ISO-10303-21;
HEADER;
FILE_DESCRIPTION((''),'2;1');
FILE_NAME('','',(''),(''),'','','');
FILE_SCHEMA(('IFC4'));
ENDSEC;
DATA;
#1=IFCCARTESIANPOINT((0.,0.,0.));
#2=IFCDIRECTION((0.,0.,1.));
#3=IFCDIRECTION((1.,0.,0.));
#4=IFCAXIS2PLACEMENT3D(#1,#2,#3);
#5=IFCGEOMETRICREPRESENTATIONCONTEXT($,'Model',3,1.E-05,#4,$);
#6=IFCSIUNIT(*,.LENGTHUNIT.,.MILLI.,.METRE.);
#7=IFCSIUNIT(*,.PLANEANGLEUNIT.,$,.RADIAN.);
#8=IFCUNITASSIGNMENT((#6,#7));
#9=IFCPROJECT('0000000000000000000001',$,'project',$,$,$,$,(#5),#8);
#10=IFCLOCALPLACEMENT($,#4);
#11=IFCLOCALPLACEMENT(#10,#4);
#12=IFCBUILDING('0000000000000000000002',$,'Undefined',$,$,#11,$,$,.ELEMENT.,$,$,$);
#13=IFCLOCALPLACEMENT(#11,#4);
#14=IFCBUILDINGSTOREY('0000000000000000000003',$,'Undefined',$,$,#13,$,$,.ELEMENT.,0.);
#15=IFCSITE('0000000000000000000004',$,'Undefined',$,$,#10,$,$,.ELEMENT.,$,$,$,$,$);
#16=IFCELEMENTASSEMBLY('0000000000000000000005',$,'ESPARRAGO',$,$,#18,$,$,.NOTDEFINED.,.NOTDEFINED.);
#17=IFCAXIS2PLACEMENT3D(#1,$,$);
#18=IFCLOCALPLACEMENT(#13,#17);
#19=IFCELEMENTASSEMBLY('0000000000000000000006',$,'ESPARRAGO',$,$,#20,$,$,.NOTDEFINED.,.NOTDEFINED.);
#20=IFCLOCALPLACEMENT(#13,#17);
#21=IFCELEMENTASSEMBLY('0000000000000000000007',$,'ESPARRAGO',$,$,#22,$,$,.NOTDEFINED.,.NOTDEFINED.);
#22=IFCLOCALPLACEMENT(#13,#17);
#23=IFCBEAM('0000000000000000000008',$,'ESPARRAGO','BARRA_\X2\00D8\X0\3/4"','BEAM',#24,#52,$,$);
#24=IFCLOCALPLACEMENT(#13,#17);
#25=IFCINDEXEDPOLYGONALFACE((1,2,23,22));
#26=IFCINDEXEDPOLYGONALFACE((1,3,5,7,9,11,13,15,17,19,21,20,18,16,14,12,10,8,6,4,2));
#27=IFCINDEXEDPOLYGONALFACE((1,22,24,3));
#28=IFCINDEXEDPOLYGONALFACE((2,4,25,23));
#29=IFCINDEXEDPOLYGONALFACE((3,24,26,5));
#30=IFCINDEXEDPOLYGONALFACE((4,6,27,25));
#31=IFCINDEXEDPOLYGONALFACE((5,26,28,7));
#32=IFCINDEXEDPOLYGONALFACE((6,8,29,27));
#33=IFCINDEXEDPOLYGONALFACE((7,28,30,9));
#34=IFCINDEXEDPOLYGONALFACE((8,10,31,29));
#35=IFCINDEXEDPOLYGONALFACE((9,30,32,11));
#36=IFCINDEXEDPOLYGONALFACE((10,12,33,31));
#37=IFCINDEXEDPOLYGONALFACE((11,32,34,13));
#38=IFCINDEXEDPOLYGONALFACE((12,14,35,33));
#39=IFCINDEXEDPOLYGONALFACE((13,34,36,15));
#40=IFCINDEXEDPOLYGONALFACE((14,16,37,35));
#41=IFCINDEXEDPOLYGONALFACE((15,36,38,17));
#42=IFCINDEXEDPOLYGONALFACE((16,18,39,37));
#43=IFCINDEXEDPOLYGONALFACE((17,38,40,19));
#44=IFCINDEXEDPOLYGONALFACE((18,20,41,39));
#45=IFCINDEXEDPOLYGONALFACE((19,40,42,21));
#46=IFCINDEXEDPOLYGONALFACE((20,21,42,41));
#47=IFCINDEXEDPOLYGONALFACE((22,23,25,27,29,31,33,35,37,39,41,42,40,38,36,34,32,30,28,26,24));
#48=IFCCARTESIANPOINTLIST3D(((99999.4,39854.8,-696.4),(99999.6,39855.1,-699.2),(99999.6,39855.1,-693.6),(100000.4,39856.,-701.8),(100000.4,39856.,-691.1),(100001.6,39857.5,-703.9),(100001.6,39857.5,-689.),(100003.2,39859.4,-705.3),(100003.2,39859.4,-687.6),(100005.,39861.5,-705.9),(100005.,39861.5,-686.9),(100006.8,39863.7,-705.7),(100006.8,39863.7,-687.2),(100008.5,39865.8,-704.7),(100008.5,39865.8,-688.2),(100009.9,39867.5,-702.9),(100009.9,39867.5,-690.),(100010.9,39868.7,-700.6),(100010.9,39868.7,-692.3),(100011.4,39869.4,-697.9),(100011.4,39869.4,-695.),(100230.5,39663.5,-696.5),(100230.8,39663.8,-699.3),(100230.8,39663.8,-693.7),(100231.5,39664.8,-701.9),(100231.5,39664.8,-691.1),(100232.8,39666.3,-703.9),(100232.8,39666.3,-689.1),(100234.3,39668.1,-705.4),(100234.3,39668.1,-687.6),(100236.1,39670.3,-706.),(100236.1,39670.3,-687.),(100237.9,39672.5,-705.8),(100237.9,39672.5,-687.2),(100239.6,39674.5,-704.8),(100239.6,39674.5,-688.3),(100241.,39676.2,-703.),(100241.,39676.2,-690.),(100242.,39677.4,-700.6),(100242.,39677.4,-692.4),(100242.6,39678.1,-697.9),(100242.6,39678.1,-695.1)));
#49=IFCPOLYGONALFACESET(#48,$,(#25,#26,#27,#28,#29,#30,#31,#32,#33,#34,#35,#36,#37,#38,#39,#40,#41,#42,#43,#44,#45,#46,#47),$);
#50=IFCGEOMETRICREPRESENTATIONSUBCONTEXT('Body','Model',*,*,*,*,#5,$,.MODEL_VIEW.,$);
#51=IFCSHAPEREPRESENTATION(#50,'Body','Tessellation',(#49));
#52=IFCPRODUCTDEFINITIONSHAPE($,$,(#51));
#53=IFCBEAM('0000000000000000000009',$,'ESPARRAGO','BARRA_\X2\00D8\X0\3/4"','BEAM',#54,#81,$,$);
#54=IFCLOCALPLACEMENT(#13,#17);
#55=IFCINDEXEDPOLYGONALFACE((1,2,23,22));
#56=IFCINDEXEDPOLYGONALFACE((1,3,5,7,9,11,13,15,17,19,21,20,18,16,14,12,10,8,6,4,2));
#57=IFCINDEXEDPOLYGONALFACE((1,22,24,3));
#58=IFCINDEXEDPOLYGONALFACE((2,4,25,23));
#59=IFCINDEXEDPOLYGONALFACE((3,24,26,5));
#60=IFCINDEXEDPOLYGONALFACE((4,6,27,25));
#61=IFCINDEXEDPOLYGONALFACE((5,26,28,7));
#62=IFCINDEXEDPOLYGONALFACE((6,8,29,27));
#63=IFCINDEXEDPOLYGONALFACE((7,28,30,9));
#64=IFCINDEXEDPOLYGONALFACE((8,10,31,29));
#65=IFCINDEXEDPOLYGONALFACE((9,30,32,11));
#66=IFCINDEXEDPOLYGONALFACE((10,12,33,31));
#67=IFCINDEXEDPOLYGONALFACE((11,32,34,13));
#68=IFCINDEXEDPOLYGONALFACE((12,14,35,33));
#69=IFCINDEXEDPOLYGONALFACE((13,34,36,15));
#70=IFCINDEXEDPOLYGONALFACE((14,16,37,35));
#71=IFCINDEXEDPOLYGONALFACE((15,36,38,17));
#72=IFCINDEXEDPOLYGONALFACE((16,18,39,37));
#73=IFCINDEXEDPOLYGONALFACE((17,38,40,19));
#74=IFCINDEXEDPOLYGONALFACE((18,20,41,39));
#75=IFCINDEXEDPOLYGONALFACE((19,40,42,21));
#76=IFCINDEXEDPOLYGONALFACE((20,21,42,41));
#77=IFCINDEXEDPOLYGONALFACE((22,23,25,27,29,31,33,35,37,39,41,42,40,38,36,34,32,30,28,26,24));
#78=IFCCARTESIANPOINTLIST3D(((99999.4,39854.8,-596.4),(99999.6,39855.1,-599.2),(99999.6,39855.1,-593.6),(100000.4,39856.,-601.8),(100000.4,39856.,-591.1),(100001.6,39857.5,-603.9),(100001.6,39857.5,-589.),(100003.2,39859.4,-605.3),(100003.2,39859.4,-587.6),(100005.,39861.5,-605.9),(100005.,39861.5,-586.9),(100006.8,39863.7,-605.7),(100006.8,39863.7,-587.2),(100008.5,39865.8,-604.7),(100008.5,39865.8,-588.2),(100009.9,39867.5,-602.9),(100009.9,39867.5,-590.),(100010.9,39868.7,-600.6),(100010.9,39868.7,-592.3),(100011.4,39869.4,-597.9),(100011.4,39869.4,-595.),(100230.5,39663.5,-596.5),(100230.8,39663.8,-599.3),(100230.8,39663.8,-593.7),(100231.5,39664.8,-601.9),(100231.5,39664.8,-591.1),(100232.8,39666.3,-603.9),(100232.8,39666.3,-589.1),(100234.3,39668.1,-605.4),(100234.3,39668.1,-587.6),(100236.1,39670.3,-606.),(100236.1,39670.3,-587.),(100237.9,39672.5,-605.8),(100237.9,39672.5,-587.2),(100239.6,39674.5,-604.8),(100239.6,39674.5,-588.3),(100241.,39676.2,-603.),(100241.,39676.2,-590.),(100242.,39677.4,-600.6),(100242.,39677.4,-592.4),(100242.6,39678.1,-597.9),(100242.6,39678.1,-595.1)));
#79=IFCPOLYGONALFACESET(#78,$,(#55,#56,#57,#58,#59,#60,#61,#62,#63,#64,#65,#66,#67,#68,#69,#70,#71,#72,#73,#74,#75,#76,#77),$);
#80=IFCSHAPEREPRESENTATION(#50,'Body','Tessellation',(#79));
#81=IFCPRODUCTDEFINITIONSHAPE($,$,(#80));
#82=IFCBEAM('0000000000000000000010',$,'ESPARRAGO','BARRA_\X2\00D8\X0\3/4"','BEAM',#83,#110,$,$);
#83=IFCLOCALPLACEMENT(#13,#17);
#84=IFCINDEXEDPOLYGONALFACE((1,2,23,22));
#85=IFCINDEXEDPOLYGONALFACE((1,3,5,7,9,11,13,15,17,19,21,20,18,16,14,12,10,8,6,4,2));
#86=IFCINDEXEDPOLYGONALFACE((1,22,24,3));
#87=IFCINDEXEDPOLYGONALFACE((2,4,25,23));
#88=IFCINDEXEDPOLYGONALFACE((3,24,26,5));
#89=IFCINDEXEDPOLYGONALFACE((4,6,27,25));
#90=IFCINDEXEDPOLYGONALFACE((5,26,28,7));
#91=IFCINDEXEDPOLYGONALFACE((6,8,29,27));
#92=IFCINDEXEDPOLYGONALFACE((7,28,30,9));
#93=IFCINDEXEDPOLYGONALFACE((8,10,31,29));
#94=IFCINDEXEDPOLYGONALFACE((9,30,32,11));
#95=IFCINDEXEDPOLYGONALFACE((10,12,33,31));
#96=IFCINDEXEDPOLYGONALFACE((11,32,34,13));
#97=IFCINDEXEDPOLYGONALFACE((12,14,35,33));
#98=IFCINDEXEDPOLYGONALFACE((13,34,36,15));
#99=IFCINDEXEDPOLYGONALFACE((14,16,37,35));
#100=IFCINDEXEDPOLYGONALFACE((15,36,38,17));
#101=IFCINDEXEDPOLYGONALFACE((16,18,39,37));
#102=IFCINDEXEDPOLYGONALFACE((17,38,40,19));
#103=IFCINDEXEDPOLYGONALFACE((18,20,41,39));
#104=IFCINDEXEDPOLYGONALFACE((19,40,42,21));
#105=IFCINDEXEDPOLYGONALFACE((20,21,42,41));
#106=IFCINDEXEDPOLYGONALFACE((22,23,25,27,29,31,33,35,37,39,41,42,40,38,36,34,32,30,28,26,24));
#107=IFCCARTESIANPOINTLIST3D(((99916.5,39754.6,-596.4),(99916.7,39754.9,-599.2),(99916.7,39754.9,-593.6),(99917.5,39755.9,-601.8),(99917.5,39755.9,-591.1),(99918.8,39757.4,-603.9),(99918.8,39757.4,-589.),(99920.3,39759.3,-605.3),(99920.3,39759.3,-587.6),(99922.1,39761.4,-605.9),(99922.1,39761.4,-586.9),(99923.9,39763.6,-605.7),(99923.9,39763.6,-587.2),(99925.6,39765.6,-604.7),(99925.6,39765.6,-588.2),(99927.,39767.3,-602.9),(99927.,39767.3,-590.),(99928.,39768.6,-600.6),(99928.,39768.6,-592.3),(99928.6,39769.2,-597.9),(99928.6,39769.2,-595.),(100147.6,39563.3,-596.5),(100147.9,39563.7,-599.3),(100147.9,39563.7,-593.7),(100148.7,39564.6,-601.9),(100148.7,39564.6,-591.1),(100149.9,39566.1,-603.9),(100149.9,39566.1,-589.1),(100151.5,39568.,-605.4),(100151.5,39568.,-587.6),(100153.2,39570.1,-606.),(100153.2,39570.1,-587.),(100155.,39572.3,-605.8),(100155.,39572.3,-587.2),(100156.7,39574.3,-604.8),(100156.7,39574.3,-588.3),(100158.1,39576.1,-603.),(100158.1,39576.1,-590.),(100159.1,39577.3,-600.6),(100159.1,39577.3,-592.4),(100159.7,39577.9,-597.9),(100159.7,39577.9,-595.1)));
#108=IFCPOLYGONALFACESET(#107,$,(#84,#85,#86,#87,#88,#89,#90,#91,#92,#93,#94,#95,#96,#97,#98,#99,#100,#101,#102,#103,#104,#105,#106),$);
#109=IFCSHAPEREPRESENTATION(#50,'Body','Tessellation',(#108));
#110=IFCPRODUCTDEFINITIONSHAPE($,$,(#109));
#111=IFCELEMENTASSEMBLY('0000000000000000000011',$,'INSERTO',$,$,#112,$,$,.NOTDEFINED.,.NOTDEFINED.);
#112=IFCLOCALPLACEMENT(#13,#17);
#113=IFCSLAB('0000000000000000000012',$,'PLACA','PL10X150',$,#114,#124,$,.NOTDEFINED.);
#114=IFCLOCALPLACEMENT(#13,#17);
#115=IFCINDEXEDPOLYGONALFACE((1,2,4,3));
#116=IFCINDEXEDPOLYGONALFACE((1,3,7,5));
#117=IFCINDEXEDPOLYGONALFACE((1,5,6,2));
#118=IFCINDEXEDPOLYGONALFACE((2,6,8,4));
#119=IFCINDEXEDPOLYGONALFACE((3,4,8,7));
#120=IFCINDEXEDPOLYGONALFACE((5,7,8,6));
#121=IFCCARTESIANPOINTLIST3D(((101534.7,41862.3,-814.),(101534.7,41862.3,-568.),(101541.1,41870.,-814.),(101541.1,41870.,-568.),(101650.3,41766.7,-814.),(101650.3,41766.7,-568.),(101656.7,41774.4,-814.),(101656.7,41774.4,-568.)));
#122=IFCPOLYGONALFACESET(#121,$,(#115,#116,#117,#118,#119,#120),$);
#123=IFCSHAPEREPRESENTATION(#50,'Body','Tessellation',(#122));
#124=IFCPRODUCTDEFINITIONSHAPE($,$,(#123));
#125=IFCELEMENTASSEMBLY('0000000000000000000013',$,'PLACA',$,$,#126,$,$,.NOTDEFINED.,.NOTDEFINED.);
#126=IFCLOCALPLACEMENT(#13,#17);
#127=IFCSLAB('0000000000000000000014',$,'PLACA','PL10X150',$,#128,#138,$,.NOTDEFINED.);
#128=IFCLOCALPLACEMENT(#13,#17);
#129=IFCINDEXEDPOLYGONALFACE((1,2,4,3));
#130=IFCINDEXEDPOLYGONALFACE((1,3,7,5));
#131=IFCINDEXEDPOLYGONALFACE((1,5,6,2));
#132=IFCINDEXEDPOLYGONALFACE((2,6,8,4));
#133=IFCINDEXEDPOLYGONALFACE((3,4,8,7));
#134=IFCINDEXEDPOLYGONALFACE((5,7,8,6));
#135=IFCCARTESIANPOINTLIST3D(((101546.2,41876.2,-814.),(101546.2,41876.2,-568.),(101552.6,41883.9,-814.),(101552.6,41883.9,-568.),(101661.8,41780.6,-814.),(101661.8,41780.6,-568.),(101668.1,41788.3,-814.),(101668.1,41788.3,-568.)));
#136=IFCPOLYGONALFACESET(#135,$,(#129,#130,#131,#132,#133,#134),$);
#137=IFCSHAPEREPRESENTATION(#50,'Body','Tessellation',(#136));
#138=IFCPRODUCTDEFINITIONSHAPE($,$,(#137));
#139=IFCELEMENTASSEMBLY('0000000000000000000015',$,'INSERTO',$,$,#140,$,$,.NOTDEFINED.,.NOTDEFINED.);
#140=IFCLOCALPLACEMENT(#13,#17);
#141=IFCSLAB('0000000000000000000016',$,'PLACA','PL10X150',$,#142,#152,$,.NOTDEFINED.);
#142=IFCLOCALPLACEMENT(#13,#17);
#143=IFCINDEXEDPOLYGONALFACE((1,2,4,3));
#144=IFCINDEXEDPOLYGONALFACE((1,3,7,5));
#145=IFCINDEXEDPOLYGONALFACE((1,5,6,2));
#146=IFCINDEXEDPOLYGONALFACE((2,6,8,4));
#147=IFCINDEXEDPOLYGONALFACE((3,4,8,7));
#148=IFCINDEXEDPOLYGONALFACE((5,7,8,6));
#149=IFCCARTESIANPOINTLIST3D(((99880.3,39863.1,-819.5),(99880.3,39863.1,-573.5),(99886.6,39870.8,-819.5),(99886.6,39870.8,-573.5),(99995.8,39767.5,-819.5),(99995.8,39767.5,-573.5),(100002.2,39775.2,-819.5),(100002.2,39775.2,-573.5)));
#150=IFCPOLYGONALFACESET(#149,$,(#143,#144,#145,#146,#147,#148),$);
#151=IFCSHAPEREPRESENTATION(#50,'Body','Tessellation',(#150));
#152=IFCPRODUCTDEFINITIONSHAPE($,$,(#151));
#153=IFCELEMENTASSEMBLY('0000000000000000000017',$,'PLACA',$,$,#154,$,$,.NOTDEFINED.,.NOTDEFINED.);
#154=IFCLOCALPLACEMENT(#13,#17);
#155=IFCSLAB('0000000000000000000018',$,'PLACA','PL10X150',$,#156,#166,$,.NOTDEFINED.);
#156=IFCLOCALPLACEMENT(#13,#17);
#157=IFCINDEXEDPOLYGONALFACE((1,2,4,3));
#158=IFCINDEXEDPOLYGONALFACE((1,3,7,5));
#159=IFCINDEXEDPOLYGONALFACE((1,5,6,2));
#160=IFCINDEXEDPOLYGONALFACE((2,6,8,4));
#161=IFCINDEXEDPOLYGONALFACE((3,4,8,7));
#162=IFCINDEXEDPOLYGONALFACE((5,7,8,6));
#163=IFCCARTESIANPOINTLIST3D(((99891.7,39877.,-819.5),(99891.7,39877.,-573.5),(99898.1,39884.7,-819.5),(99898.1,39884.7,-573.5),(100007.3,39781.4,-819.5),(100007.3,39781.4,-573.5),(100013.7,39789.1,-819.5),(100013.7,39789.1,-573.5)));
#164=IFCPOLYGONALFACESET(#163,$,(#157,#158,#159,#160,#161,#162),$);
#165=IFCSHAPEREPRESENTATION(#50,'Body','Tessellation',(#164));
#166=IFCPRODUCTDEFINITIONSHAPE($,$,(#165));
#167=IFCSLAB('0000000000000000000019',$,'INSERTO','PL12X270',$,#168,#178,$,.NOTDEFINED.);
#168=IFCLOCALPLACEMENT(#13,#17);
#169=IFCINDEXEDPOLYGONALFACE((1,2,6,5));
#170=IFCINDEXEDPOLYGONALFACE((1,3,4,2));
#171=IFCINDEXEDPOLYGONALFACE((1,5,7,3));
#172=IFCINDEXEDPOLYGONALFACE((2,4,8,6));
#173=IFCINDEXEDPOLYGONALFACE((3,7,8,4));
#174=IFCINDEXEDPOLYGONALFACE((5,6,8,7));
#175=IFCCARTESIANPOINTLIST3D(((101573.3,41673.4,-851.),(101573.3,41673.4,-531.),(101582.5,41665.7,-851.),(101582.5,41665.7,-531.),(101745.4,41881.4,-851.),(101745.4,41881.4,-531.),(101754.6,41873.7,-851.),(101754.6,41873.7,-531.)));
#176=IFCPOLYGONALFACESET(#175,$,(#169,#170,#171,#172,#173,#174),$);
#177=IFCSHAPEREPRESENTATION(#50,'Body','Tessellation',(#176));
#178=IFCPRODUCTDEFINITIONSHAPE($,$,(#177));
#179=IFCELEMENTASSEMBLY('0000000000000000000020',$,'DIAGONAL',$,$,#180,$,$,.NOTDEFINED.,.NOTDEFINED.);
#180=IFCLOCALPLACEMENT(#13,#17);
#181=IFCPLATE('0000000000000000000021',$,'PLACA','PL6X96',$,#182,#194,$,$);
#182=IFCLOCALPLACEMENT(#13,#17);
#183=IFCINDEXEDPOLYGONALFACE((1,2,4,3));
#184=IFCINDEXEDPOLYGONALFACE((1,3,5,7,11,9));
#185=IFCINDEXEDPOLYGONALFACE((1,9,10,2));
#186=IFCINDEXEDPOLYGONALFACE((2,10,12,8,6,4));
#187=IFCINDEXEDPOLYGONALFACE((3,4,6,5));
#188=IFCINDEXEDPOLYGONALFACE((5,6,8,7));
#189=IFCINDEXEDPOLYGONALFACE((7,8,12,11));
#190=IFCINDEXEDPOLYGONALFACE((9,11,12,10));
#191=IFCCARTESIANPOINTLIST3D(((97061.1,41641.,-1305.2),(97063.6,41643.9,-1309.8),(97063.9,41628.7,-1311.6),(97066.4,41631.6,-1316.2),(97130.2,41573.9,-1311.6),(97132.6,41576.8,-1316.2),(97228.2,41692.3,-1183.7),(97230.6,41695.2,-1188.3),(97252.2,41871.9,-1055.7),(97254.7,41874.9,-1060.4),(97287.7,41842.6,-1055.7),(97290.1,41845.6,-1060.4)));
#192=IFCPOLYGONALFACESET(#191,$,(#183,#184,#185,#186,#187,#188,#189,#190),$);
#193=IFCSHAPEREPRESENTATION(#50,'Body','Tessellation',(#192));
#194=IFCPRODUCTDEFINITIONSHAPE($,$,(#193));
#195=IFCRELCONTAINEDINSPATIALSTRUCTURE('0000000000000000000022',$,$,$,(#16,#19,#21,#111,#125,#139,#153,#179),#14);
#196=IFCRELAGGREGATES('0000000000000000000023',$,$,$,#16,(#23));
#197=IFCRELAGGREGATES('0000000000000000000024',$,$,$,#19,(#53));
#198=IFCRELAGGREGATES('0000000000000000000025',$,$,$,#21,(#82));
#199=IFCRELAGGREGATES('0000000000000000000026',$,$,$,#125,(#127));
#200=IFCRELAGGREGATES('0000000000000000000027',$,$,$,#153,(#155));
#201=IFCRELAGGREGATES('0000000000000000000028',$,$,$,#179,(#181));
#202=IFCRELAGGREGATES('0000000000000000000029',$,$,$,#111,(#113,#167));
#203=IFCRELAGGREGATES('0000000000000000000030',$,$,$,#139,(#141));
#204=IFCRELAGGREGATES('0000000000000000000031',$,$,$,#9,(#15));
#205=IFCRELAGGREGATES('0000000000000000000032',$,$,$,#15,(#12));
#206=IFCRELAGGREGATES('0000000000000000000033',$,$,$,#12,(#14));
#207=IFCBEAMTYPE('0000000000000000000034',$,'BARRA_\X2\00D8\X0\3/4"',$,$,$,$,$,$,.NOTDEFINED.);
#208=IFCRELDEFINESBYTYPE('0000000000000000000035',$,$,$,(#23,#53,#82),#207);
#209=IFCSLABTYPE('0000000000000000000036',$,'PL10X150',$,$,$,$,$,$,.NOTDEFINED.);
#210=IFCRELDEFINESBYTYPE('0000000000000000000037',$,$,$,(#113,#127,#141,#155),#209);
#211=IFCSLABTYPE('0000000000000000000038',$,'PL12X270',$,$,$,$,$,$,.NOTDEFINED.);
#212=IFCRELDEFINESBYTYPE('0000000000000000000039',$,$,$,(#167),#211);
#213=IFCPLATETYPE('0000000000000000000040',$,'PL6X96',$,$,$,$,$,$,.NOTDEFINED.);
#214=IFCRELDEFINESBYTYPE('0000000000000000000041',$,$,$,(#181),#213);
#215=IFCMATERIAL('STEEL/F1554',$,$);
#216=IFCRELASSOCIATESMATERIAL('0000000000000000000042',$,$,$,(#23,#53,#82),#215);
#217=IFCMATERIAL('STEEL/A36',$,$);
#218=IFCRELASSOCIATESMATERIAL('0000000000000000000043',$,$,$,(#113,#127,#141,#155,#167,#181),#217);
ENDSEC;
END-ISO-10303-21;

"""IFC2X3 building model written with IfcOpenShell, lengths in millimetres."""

from ifc_helpers import new_model, si_unit, frame, origin_with_axes, origin_2d_with_axis, place, context, subcontext, project, spatial, polyline, circle, outline, extrude, material, type_object, element, aggregate, save


model = new_model("IFC2X3")

# Units and contexts
model_context = context("Model", 3, precision=1e-05, world=origin_with_axes())
body_context = subcontext(model_context, "Body", "Model", "MODEL_VIEW")
ifc_project = project(units=[si_unit("LENGTHUNIT", "METRE", prefix="MILLI"), si_unit("PLANEANGLEUNIT", "RADIAN")], contexts=[model_context])

# Site, building, storey
site_placement = place(None, origin_with_axes())
site = spatial("IfcSite", under=ifc_project, at=site_placement, Name="Undefined", CompositionType="ELEMENT")
building_placement = place(site_placement, origin_with_axes())
building = spatial("IfcBuilding", under=site, at=building_placement, Name="Undefined", CompositionType="ELEMENT")
storey_placement = place(building_placement, origin_with_axes())
storey = spatial("IfcBuildingStorey", under=building, at=storey_placement, Name="Undefined", CompositionType="ELEMENT", Elevation=0.0)

# Element assemblies
assembly_1_placement = place(storey_placement, origin_with_axes())
assembly_1 = element("IfcElementAssembly", 1, at=assembly_1_placement, inside=storey, Name="ESPARRAGO", AssemblyPlace="NOTDEFINED", PredefinedType="NOTDEFINED")
assembly_2_placement = place(storey_placement, origin_with_axes())
assembly_2 = element("IfcElementAssembly", 2, at=assembly_2_placement, inside=storey, Name="ESPARRAGO", AssemblyPlace="NOTDEFINED", PredefinedType="NOTDEFINED")
assembly_3_placement = place(storey_placement, origin_with_axes())
assembly_3 = element("IfcElementAssembly", 3, at=assembly_3_placement, inside=storey, Name="ESPARRAGO", AssemblyPlace="NOTDEFINED", PredefinedType="NOTDEFINED")

# Beams
ifc_material_1 = material(Name="STEEL/F1554")
beam_type_1 = type_object("IfcBeamType", Name="BARRA_Ø3/4\"", PredefinedType="NOTDEFINED")
beam_1_placement = place(assembly_1_placement, frame((100005.4, 39862.1, -696.4), z_axis=(0.000162, -0.000134, 1.0), x_axis=(0.770403, -0.637558, -0.000211)))
beam_1 = element("IfcBeam", 4, at=beam_1_placement, type_object=beam_type_1, material=ifc_material_1, Name="ESPARRAGO", Description="BARRA_Ø3/4\"", ObjectType="BEAM", context=body_context, shape_type="SweptSolid", body=[
    extrude(circle(Radius=9.5, at=origin_2d_with_axis()), frame((300.0, 0.0, 0.0), z_axis=(-1.0, 0.0, 0.0), x_axis=(0.0, -1.0, 0.0)), (0.0, 0.0, 1.0), 300.0),
])
aggregate(assembly_1, [beam_1])
beam_2_placement = place(assembly_2_placement, frame((100005.4, 39862.1, -596.4), z_axis=(0.000162, -0.000134, 1.0), x_axis=(0.770403, -0.637558, -0.000211)))
beam_2 = element("IfcBeam", 5, at=beam_2_placement, type_object=beam_type_1, material=ifc_material_1, Name="ESPARRAGO", Description="BARRA_Ø3/4\"", ObjectType="BEAM", context=body_context, shape_type="SweptSolid", body=[
    extrude(circle(Radius=9.5, at=origin_2d_with_axis()), frame((300.0, 0.0, 0.0), z_axis=(-1.0, 0.0, 0.0), x_axis=(0.0, -1.0, 0.0)), (0.0, 0.0, 1.0), 300.0),
])
aggregate(assembly_2, [beam_2])
beam_3_placement = place(assembly_3_placement, frame((99922.6, 39761.9, -596.4), z_axis=(0.000162, -0.000134, 1.0), x_axis=(0.770403, -0.637558, -0.000211)))
beam_3 = element("IfcBeam", 6, at=beam_3_placement, type_object=beam_type_1, material=ifc_material_1, Name="ESPARRAGO", Description="BARRA_Ø3/4\"", ObjectType="BEAM", context=body_context, shape_type="SweptSolid", body=[
    extrude(circle(Radius=9.5, at=origin_2d_with_axis()), frame((300.0, 0.0, 0.0), z_axis=(-1.0, 0.0, 0.0), x_axis=(0.0, -1.0, 0.0)), (0.0, 0.0, 1.0), 300.0),
])
aggregate(assembly_3, [beam_3])

# Element assemblies, slabs
assembly_4_placement = place(storey_placement, origin_with_axes())
assembly_4 = element("IfcElementAssembly", 7, at=assembly_4_placement, inside=storey, Name="INSERTO", AssemblyPlace="NOTDEFINED", PredefinedType="NOTDEFINED")
ifc_material_2 = material(Name="STEEL/A36")
slab_type_1 = type_object("IfcSlabType", Name="PL10X150", PredefinedType="NOTDEFINED")
slab_1_placement = place(assembly_4_placement, frame((101653.5, 41770.5, -568.0), z_axis=(-0.637561, -0.7704, 0.0), x_axis=(-0.7704, 0.637561, 0.0)))
slab_1 = element("IfcSlab", 8, at=slab_1_placement, type_object=slab_type_1, material=ifc_material_2, Name="PLACA", Description="PL10X150", PredefinedType="NOTDEFINED", context=body_context, shape_type="SweptSolid", body=[
    extrude(outline(polyline([(0.0, 0.0), (150.0, 0.0), (150.0, 246.0), (0.0, 246.0), (0.0, 0.0)])), frame((0.0, 0.0, -5.0), z_axis=(0.0, 0.0, 1.0), x_axis=(1.0, 0.0, 0.0)), (0.0, 0.0, 1.0), 10.0),
])
assembly_5_placement = place(storey_placement, origin_with_axes())
assembly_5 = element("IfcElementAssembly", 9, at=assembly_5_placement, inside=storey, Name="PLACA", AssemblyPlace="NOTDEFINED", PredefinedType="NOTDEFINED")
slab_2_placement = place(assembly_5_placement, frame((101664.9, 41784.4, -568.0), z_axis=(-0.637561, -0.7704, 0.0), x_axis=(-0.7704, 0.637561, 0.0)))
slab_2 = element("IfcSlab", 10, at=slab_2_placement, type_object=slab_type_1, material=ifc_material_2, Name="PLACA", Description="PL10X150", PredefinedType="NOTDEFINED", context=body_context, shape_type="SweptSolid", body=[
    extrude(outline(polyline([(0.0, 0.0), (150.0, 0.0), (150.0, 246.0), (0.0, 246.0), (0.0, 0.0)])), frame((0.0, 0.0, -5.0), z_axis=(0.0, 0.0, 1.0), x_axis=(1.0, 0.0, 0.0)), (0.0, 0.0, 1.0), 10.0),
])
aggregate(assembly_5, [slab_2])
assembly_6_placement = place(storey_placement, origin_with_axes())
assembly_6 = element("IfcElementAssembly", 11, at=assembly_6_placement, inside=storey, Name="INSERTO", AssemblyPlace="NOTDEFINED", PredefinedType="NOTDEFINED")
slab_3_placement = place(assembly_6_placement, frame((99999.0, 39771.4, -573.5), z_axis=(-0.637561, -0.7704, 0.0), x_axis=(-0.7704, 0.637561, 0.0)))
slab_3 = element("IfcSlab", 12, at=slab_3_placement, type_object=slab_type_1, material=ifc_material_2, Name="PLACA", Description="PL10X150", PredefinedType="NOTDEFINED", context=body_context, shape_type="SweptSolid", body=[
    extrude(outline(polyline([(0.0, 0.0), (150.0, 0.0), (150.0, 246.0), (0.0, 246.0), (0.0, 0.0)])), frame((0.0, 0.0, -5.0), z_axis=(0.0, 0.0, 1.0), x_axis=(1.0, 0.0, 0.0)), (0.0, 0.0, 1.0), 10.0),
])
assembly_7_placement = place(storey_placement, origin_with_axes())
assembly_7 = element("IfcElementAssembly", 13, at=assembly_7_placement, inside=storey, Name="PLACA", AssemblyPlace="NOTDEFINED", PredefinedType="NOTDEFINED")
slab_4_placement = place(assembly_7_placement, frame((100010.5, 39785.2, -573.5), z_axis=(-0.637561, -0.7704, 0.0), x_axis=(-0.7704, 0.637561, 0.0)))
slab_4 = element("IfcSlab", 14, at=slab_4_placement, type_object=slab_type_1, material=ifc_material_2, Name="PLACA", Description="PL10X150", PredefinedType="NOTDEFINED", context=body_context, shape_type="SweptSolid", body=[
    extrude(outline(polyline([(0.0, 0.0), (150.0, 0.0), (150.0, 246.0), (0.0, 246.0), (0.0, 0.0)])), frame((0.0, 0.0, -5.0), z_axis=(0.0, 0.0, 1.0), x_axis=(1.0, 0.0, 0.0)), (0.0, 0.0, 1.0), 10.0),
])
aggregate(assembly_7, [slab_4])

# Slab
slab_type_2 = type_object("IfcSlabType", Name="PL12X270", PredefinedType="NOTDEFINED")
slab_5_placement = place(assembly_4_placement, frame((101577.9, 41669.6, -531.0), z_axis=(-0.7704, 0.637561, 0.0), x_axis=(0.637561, 0.7704, -0.000001)))
slab_5 = element("IfcSlab", 15, at=slab_5_placement, type_object=slab_type_2, material=ifc_material_2, Name="INSERTO", Description="PL12X270", PredefinedType="NOTDEFINED", context=body_context, shape_type="SweptSolid", body=[
    extrude(outline(polyline([(0.0, 0.0), (270.0, 0.0), (270.0, 320.0), (0.0, 320.0), (0.0, 0.0)])), frame((0.0, 0.0, -6.0), z_axis=(0.0, 0.0, 1.0), x_axis=(1.0, 0.0, 0.0)), (0.0, 0.0, 1.0), 12.0),
])

# Element assembly, plate
assembly_8_placement = place(storey_placement, origin_with_axes())
assembly_8 = element("IfcElementAssembly", 16, at=assembly_8_placement, inside=storey, Name="DIAGONAL", AssemblyPlace="NOTDEFINED", PredefinedType="NOTDEFINED")
plate_type_1 = type_object("IfcPlateType", Name="PL6X96", PredefinedType="NOTDEFINED")
plate_1_placement = place(assembly_8_placement, frame((97131.4, 41575.3, -1313.9), z_axis=(0.407839, 0.492816, -0.768635), x_axis=(-0.770401, 0.63756, 0.0)))
plate_1 = element("IfcPlate", 17, at=plate_1_placement, type_object=plate_type_1, material=ifc_material_2, Name="PLACA", Description="PL6X96", context=body_context, shape_type="SweptSolid", body=[
    extrude(outline(polyline([(0.0, 0.0), (86.0, 0.0), (96.0, 10.0), (96.0, 400.0), (50.0, 400.0), (0.0, 200.0), (0.0, 0.0)])), frame((0.0, 0.0, -3.0), z_axis=(0.0, 0.0, 1.0), x_axis=(1.0, 0.0, 0.0)), (0.0, 0.0, 1.0), 6.0),
])
aggregate(assembly_8, [plate_1])

aggregate(assembly_4, [slab_1, slab_5])
aggregate(assembly_6, [slab_3])

save(model, "model.ifc")
